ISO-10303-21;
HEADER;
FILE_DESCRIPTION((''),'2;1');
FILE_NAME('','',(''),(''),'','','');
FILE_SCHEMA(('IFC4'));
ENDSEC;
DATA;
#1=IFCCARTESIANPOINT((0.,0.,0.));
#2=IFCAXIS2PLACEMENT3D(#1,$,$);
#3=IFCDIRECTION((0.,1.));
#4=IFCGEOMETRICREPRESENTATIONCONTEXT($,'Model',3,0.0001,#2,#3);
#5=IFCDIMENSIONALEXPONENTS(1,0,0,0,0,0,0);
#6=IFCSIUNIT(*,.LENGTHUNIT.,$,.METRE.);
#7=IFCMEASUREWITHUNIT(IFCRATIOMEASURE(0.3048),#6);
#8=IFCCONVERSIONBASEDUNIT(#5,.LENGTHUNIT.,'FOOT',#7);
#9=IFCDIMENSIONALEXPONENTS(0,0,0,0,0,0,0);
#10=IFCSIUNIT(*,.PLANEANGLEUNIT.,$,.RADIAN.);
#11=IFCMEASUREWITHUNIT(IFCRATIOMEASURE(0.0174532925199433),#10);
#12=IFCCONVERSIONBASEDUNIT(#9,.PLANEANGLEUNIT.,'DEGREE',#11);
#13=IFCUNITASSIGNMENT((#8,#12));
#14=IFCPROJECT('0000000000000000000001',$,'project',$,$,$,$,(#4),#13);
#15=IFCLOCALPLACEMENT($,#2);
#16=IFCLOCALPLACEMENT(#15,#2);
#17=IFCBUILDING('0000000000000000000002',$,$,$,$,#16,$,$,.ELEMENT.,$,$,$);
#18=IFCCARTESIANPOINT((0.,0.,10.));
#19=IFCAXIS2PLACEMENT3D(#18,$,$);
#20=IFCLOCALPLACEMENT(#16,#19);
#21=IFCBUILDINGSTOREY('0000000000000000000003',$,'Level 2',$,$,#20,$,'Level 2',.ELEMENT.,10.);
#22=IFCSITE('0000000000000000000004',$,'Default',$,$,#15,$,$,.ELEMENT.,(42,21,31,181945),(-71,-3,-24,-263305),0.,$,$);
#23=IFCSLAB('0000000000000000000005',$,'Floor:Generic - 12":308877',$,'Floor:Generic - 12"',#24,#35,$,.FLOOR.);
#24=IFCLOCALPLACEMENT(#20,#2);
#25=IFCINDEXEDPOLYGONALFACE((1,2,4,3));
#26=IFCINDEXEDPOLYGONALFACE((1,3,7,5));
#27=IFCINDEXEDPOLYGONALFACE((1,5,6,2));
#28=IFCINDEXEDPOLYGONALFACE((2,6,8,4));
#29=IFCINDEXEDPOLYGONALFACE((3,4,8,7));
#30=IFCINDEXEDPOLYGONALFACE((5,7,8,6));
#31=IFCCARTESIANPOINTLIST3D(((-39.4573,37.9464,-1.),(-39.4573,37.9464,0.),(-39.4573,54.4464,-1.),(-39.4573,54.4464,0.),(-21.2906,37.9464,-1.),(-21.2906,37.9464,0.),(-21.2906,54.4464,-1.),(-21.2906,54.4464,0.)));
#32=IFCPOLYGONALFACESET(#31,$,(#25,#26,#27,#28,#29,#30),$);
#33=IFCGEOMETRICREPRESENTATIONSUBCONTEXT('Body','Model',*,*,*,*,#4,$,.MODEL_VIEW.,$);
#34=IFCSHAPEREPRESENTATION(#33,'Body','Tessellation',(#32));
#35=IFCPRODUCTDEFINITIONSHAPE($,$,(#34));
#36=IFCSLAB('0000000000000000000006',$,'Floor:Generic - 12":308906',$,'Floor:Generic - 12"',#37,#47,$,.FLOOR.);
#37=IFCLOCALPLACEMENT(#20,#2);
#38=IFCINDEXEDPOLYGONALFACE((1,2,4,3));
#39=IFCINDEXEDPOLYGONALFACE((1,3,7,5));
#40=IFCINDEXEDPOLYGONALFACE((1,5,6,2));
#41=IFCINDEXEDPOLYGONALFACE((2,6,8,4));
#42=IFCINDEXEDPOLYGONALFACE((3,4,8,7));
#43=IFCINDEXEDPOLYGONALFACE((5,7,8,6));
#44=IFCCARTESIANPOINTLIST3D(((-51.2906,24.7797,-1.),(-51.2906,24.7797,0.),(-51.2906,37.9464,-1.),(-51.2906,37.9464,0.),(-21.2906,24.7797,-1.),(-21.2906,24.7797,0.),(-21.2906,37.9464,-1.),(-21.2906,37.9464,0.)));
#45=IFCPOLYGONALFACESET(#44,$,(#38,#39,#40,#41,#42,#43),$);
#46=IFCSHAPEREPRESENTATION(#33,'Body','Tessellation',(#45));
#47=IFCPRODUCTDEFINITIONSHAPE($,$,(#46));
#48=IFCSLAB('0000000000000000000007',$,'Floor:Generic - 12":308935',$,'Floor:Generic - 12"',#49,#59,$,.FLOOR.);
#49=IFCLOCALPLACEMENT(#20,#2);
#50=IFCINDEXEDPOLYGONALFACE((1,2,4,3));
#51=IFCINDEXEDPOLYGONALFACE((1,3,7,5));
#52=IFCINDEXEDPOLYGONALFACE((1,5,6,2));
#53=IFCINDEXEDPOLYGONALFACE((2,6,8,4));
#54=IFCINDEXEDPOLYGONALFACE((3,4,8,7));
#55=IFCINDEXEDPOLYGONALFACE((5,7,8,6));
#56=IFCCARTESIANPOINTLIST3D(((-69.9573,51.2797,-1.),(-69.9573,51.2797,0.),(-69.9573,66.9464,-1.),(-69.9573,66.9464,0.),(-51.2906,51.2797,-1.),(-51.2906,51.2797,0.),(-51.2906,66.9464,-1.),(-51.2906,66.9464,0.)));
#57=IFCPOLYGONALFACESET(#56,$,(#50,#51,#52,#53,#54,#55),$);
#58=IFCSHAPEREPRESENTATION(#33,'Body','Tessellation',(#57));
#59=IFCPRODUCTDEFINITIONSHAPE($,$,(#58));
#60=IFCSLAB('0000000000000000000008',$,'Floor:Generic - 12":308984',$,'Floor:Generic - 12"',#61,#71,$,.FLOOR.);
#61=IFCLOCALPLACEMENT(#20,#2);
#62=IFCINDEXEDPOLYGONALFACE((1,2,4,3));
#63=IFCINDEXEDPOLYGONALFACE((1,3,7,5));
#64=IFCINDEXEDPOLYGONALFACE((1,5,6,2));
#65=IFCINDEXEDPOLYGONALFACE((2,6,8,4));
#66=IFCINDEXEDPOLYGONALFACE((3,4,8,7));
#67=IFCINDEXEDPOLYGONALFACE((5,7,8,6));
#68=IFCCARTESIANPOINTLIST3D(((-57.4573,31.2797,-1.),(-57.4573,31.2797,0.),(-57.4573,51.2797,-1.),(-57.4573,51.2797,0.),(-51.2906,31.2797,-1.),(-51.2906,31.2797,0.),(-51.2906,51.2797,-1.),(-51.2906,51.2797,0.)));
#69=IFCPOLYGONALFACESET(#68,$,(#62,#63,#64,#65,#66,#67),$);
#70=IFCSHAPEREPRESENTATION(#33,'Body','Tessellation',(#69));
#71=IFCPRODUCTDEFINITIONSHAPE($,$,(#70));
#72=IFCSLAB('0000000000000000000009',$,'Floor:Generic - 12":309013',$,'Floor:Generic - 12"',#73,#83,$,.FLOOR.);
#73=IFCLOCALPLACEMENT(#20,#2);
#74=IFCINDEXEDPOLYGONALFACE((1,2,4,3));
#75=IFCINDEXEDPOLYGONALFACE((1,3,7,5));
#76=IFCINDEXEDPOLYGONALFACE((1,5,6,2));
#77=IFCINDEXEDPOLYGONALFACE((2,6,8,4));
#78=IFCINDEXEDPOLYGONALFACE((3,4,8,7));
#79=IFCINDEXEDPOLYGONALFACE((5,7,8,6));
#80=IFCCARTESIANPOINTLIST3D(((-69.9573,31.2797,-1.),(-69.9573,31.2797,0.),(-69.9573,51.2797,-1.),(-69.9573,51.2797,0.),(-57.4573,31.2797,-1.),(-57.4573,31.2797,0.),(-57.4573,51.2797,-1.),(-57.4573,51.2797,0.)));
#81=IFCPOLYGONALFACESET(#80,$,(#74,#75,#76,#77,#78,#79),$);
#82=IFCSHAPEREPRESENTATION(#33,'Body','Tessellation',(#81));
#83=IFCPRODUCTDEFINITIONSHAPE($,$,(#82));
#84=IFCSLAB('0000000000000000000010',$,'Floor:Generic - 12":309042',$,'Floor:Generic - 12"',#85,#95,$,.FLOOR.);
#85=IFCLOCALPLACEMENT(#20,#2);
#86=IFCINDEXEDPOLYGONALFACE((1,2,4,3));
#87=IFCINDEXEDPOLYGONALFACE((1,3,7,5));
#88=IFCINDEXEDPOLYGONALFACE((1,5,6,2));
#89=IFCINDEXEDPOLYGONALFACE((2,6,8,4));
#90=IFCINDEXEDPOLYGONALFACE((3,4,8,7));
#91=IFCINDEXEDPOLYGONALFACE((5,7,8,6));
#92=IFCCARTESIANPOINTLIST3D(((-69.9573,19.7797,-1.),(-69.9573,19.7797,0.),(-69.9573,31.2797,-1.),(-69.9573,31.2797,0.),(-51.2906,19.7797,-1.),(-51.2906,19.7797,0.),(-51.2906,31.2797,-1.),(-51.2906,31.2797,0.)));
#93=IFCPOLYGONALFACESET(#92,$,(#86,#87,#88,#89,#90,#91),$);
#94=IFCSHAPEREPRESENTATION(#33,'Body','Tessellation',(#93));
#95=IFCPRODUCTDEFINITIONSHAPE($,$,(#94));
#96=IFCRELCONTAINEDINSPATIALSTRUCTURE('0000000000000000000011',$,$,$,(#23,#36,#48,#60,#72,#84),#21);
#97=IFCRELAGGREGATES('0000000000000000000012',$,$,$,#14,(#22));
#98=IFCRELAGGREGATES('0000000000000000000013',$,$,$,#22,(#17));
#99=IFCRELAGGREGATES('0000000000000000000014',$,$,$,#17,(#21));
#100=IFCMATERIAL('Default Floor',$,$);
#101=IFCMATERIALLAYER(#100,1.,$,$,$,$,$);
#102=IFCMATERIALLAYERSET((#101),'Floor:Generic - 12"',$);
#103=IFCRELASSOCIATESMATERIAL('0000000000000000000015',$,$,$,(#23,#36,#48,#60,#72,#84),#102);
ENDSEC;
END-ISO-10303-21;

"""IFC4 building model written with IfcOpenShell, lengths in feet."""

from ifc_helpers import new_model, entity, si_unit, converted_unit, direction, frame, frame_2d, origin, place, context, subcontext, project, spatial, rectangle, extrude, material, layer, layer_set, layer_usage, element, save


model = new_model("IFC4")

# Units and contexts
model_context = context("Model", 3, precision=0.0001, world=origin(), true_north=direction((0.0, 1.0)))
body_context = subcontext(model_context, "Body", "Model", "MODEL_VIEW")
ifc_project = project(units=[converted_unit("LENGTHUNIT", "FOOT", entity("IfcRatioMeasure", 0.3048), si_unit("LENGTHUNIT", "METRE"), dimensions=[1, 0, 0, 0, 0, 0, 0]), converted_unit("PLANEANGLEUNIT", "DEGREE", entity("IfcRatioMeasure", 0.0174532925199433), si_unit("PLANEANGLEUNIT", "RADIAN"), dimensions=[0, 0, 0, 0, 0, 0, 0])], contexts=[model_context])

# Site, building, storey
site_placement = place(None, origin())
site = spatial("IfcSite", under=ifc_project, at=site_placement, Name="Default", CompositionType="ELEMENT", RefLatitude=(42, 21, 31, 181945), RefLongitude=(-71, -3, -24, -263305), RefElevation=0.0)
building_placement = place(site_placement, origin())
building = spatial("IfcBuilding", under=site, at=building_placement, CompositionType="ELEMENT")
storey_placement = place(building_placement, frame((0.0, 0.0, 10.0)))
storey = spatial("IfcBuildingStorey", under=building, at=storey_placement, Name="Level 2", LongName="Level 2", CompositionType="ELEMENT", Elevation=10.0)

# Slabs
ifc_material = material(Name="Default Floor")
ifc_layer = layer(ifc_material, 1.0)
ifc_layer_set = layer_set([ifc_layer], Name="Floor:Generic - 12\"")
ifc_layer_usage_1 = layer_usage(ifc_layer_set, "AXIS3", "POSITIVE", 0.0)
slab_1_placement = place(storey_placement, origin())
element("IfcSlab", 1, at=slab_1_placement, inside=storey, material=ifc_layer_usage_1, Name="Floor:Generic - 12\":308877", ObjectType="Floor:Generic - 12\"", PredefinedType="FLOOR", context=body_context, shape_type="SweptSolid", body=[
    extrude(rectangle(XDim=16.5, YDim=18.1667, at=frame_2d((0.0, 0.0), x_axis=(1.0, 0.0))), frame((-30.3739, 46.1964, 0.0), z_axis=(0.0, 0.0, -1.0), x_axis=(0.0, 1.0, 0.0)), (0.0, 0.0, 1.0), 1.0),
])
ifc_layer_usage_2 = layer_usage(ifc_layer_set, "AXIS3", "POSITIVE", 0.0)
slab_2_placement = place(storey_placement, origin())
element("IfcSlab", 2, at=slab_2_placement, inside=storey, material=ifc_layer_usage_2, Name="Floor:Generic - 12\":308906", ObjectType="Floor:Generic - 12\"", PredefinedType="FLOOR", context=body_context, shape_type="SweptSolid", body=[
    extrude(rectangle(XDim=13.1667, YDim=30.0, at=frame_2d((0.0, 0.0), x_axis=(1.0, 0.0))), frame((-36.2906, 31.3631, 0.0), z_axis=(0.0, 0.0, -1.0), x_axis=(0.0, 1.0, 0.0)), (0.0, 0.0, 1.0), 1.0),
])
ifc_layer_usage_3 = layer_usage(ifc_layer_set, "AXIS3", "POSITIVE", 0.0)
slab_3_placement = place(storey_placement, origin())
element("IfcSlab", 3, at=slab_3_placement, inside=storey, material=ifc_layer_usage_3, Name="Floor:Generic - 12\":308935", ObjectType="Floor:Generic - 12\"", PredefinedType="FLOOR", context=body_context, shape_type="SweptSolid", body=[
    extrude(rectangle(XDim=15.6667, YDim=18.6667, at=frame_2d((0.0, 0.0), x_axis=(1.0, 0.0))), frame((-60.6239, 59.1131, 0.0), z_axis=(0.0, 0.0, -1.0), x_axis=(0.0, 1.0, 0.0)), (0.0, 0.0, 1.0), 1.0),
])
ifc_layer_usage_4 = layer_usage(ifc_layer_set, "AXIS3", "POSITIVE", 0.0)
slab_4_placement = place(storey_placement, origin())
element("IfcSlab", 4, at=slab_4_placement, inside=storey, material=ifc_layer_usage_4, Name="Floor:Generic - 12\":308984", ObjectType="Floor:Generic - 12\"", PredefinedType="FLOOR", context=body_context, shape_type="SweptSolid", body=[
    extrude(rectangle(XDim=20.0, YDim=6.1667, at=frame_2d((0.0, 0.0), x_axis=(1.0, 0.0))), frame((-54.3739, 41.2797, 0.0), z_axis=(0.0, 0.0, -1.0), x_axis=(0.0, 1.0, 0.0)), (0.0, 0.0, 1.0), 1.0),
])
ifc_layer_usage_5 = layer_usage(ifc_layer_set, "AXIS3", "POSITIVE", 0.0)
slab_5_placement = place(storey_placement, origin())
element("IfcSlab", 5, at=slab_5_placement, inside=storey, material=ifc_layer_usage_5, Name="Floor:Generic - 12\":309013", ObjectType="Floor:Generic - 12\"", PredefinedType="FLOOR", context=body_context, shape_type="SweptSolid", body=[
    extrude(rectangle(XDim=20.0, YDim=12.5, at=frame_2d((0.0, 0.0), x_axis=(1.0, 0.0))), frame((-63.7073, 41.2797, 0.0), z_axis=(0.0, 0.0, -1.0), x_axis=(0.0, 1.0, 0.0)), (0.0, 0.0, 1.0), 1.0),
])
ifc_layer_usage_6 = layer_usage(ifc_layer_set, "AXIS3", "POSITIVE", 0.0)
slab_6_placement = place(storey_placement, origin())
element("IfcSlab", 6, at=slab_6_placement, inside=storey, material=ifc_layer_usage_6, Name="Floor:Generic - 12\":309042", ObjectType="Floor:Generic - 12\"", PredefinedType="FLOOR", context=body_context, shape_type="SweptSolid", body=[
    extrude(rectangle(XDim=11.5, YDim=18.6667, at=frame_2d((0.0, 0.0), x_axis=(1.0, 0.0))), frame((-60.6239, 25.5297, 0.0), z_axis=(0.0, 0.0, -1.0), x_axis=(0.0, 1.0, 0.0)), (0.0, 0.0, 1.0), 1.0),
])

save(model, "model.ifc")
